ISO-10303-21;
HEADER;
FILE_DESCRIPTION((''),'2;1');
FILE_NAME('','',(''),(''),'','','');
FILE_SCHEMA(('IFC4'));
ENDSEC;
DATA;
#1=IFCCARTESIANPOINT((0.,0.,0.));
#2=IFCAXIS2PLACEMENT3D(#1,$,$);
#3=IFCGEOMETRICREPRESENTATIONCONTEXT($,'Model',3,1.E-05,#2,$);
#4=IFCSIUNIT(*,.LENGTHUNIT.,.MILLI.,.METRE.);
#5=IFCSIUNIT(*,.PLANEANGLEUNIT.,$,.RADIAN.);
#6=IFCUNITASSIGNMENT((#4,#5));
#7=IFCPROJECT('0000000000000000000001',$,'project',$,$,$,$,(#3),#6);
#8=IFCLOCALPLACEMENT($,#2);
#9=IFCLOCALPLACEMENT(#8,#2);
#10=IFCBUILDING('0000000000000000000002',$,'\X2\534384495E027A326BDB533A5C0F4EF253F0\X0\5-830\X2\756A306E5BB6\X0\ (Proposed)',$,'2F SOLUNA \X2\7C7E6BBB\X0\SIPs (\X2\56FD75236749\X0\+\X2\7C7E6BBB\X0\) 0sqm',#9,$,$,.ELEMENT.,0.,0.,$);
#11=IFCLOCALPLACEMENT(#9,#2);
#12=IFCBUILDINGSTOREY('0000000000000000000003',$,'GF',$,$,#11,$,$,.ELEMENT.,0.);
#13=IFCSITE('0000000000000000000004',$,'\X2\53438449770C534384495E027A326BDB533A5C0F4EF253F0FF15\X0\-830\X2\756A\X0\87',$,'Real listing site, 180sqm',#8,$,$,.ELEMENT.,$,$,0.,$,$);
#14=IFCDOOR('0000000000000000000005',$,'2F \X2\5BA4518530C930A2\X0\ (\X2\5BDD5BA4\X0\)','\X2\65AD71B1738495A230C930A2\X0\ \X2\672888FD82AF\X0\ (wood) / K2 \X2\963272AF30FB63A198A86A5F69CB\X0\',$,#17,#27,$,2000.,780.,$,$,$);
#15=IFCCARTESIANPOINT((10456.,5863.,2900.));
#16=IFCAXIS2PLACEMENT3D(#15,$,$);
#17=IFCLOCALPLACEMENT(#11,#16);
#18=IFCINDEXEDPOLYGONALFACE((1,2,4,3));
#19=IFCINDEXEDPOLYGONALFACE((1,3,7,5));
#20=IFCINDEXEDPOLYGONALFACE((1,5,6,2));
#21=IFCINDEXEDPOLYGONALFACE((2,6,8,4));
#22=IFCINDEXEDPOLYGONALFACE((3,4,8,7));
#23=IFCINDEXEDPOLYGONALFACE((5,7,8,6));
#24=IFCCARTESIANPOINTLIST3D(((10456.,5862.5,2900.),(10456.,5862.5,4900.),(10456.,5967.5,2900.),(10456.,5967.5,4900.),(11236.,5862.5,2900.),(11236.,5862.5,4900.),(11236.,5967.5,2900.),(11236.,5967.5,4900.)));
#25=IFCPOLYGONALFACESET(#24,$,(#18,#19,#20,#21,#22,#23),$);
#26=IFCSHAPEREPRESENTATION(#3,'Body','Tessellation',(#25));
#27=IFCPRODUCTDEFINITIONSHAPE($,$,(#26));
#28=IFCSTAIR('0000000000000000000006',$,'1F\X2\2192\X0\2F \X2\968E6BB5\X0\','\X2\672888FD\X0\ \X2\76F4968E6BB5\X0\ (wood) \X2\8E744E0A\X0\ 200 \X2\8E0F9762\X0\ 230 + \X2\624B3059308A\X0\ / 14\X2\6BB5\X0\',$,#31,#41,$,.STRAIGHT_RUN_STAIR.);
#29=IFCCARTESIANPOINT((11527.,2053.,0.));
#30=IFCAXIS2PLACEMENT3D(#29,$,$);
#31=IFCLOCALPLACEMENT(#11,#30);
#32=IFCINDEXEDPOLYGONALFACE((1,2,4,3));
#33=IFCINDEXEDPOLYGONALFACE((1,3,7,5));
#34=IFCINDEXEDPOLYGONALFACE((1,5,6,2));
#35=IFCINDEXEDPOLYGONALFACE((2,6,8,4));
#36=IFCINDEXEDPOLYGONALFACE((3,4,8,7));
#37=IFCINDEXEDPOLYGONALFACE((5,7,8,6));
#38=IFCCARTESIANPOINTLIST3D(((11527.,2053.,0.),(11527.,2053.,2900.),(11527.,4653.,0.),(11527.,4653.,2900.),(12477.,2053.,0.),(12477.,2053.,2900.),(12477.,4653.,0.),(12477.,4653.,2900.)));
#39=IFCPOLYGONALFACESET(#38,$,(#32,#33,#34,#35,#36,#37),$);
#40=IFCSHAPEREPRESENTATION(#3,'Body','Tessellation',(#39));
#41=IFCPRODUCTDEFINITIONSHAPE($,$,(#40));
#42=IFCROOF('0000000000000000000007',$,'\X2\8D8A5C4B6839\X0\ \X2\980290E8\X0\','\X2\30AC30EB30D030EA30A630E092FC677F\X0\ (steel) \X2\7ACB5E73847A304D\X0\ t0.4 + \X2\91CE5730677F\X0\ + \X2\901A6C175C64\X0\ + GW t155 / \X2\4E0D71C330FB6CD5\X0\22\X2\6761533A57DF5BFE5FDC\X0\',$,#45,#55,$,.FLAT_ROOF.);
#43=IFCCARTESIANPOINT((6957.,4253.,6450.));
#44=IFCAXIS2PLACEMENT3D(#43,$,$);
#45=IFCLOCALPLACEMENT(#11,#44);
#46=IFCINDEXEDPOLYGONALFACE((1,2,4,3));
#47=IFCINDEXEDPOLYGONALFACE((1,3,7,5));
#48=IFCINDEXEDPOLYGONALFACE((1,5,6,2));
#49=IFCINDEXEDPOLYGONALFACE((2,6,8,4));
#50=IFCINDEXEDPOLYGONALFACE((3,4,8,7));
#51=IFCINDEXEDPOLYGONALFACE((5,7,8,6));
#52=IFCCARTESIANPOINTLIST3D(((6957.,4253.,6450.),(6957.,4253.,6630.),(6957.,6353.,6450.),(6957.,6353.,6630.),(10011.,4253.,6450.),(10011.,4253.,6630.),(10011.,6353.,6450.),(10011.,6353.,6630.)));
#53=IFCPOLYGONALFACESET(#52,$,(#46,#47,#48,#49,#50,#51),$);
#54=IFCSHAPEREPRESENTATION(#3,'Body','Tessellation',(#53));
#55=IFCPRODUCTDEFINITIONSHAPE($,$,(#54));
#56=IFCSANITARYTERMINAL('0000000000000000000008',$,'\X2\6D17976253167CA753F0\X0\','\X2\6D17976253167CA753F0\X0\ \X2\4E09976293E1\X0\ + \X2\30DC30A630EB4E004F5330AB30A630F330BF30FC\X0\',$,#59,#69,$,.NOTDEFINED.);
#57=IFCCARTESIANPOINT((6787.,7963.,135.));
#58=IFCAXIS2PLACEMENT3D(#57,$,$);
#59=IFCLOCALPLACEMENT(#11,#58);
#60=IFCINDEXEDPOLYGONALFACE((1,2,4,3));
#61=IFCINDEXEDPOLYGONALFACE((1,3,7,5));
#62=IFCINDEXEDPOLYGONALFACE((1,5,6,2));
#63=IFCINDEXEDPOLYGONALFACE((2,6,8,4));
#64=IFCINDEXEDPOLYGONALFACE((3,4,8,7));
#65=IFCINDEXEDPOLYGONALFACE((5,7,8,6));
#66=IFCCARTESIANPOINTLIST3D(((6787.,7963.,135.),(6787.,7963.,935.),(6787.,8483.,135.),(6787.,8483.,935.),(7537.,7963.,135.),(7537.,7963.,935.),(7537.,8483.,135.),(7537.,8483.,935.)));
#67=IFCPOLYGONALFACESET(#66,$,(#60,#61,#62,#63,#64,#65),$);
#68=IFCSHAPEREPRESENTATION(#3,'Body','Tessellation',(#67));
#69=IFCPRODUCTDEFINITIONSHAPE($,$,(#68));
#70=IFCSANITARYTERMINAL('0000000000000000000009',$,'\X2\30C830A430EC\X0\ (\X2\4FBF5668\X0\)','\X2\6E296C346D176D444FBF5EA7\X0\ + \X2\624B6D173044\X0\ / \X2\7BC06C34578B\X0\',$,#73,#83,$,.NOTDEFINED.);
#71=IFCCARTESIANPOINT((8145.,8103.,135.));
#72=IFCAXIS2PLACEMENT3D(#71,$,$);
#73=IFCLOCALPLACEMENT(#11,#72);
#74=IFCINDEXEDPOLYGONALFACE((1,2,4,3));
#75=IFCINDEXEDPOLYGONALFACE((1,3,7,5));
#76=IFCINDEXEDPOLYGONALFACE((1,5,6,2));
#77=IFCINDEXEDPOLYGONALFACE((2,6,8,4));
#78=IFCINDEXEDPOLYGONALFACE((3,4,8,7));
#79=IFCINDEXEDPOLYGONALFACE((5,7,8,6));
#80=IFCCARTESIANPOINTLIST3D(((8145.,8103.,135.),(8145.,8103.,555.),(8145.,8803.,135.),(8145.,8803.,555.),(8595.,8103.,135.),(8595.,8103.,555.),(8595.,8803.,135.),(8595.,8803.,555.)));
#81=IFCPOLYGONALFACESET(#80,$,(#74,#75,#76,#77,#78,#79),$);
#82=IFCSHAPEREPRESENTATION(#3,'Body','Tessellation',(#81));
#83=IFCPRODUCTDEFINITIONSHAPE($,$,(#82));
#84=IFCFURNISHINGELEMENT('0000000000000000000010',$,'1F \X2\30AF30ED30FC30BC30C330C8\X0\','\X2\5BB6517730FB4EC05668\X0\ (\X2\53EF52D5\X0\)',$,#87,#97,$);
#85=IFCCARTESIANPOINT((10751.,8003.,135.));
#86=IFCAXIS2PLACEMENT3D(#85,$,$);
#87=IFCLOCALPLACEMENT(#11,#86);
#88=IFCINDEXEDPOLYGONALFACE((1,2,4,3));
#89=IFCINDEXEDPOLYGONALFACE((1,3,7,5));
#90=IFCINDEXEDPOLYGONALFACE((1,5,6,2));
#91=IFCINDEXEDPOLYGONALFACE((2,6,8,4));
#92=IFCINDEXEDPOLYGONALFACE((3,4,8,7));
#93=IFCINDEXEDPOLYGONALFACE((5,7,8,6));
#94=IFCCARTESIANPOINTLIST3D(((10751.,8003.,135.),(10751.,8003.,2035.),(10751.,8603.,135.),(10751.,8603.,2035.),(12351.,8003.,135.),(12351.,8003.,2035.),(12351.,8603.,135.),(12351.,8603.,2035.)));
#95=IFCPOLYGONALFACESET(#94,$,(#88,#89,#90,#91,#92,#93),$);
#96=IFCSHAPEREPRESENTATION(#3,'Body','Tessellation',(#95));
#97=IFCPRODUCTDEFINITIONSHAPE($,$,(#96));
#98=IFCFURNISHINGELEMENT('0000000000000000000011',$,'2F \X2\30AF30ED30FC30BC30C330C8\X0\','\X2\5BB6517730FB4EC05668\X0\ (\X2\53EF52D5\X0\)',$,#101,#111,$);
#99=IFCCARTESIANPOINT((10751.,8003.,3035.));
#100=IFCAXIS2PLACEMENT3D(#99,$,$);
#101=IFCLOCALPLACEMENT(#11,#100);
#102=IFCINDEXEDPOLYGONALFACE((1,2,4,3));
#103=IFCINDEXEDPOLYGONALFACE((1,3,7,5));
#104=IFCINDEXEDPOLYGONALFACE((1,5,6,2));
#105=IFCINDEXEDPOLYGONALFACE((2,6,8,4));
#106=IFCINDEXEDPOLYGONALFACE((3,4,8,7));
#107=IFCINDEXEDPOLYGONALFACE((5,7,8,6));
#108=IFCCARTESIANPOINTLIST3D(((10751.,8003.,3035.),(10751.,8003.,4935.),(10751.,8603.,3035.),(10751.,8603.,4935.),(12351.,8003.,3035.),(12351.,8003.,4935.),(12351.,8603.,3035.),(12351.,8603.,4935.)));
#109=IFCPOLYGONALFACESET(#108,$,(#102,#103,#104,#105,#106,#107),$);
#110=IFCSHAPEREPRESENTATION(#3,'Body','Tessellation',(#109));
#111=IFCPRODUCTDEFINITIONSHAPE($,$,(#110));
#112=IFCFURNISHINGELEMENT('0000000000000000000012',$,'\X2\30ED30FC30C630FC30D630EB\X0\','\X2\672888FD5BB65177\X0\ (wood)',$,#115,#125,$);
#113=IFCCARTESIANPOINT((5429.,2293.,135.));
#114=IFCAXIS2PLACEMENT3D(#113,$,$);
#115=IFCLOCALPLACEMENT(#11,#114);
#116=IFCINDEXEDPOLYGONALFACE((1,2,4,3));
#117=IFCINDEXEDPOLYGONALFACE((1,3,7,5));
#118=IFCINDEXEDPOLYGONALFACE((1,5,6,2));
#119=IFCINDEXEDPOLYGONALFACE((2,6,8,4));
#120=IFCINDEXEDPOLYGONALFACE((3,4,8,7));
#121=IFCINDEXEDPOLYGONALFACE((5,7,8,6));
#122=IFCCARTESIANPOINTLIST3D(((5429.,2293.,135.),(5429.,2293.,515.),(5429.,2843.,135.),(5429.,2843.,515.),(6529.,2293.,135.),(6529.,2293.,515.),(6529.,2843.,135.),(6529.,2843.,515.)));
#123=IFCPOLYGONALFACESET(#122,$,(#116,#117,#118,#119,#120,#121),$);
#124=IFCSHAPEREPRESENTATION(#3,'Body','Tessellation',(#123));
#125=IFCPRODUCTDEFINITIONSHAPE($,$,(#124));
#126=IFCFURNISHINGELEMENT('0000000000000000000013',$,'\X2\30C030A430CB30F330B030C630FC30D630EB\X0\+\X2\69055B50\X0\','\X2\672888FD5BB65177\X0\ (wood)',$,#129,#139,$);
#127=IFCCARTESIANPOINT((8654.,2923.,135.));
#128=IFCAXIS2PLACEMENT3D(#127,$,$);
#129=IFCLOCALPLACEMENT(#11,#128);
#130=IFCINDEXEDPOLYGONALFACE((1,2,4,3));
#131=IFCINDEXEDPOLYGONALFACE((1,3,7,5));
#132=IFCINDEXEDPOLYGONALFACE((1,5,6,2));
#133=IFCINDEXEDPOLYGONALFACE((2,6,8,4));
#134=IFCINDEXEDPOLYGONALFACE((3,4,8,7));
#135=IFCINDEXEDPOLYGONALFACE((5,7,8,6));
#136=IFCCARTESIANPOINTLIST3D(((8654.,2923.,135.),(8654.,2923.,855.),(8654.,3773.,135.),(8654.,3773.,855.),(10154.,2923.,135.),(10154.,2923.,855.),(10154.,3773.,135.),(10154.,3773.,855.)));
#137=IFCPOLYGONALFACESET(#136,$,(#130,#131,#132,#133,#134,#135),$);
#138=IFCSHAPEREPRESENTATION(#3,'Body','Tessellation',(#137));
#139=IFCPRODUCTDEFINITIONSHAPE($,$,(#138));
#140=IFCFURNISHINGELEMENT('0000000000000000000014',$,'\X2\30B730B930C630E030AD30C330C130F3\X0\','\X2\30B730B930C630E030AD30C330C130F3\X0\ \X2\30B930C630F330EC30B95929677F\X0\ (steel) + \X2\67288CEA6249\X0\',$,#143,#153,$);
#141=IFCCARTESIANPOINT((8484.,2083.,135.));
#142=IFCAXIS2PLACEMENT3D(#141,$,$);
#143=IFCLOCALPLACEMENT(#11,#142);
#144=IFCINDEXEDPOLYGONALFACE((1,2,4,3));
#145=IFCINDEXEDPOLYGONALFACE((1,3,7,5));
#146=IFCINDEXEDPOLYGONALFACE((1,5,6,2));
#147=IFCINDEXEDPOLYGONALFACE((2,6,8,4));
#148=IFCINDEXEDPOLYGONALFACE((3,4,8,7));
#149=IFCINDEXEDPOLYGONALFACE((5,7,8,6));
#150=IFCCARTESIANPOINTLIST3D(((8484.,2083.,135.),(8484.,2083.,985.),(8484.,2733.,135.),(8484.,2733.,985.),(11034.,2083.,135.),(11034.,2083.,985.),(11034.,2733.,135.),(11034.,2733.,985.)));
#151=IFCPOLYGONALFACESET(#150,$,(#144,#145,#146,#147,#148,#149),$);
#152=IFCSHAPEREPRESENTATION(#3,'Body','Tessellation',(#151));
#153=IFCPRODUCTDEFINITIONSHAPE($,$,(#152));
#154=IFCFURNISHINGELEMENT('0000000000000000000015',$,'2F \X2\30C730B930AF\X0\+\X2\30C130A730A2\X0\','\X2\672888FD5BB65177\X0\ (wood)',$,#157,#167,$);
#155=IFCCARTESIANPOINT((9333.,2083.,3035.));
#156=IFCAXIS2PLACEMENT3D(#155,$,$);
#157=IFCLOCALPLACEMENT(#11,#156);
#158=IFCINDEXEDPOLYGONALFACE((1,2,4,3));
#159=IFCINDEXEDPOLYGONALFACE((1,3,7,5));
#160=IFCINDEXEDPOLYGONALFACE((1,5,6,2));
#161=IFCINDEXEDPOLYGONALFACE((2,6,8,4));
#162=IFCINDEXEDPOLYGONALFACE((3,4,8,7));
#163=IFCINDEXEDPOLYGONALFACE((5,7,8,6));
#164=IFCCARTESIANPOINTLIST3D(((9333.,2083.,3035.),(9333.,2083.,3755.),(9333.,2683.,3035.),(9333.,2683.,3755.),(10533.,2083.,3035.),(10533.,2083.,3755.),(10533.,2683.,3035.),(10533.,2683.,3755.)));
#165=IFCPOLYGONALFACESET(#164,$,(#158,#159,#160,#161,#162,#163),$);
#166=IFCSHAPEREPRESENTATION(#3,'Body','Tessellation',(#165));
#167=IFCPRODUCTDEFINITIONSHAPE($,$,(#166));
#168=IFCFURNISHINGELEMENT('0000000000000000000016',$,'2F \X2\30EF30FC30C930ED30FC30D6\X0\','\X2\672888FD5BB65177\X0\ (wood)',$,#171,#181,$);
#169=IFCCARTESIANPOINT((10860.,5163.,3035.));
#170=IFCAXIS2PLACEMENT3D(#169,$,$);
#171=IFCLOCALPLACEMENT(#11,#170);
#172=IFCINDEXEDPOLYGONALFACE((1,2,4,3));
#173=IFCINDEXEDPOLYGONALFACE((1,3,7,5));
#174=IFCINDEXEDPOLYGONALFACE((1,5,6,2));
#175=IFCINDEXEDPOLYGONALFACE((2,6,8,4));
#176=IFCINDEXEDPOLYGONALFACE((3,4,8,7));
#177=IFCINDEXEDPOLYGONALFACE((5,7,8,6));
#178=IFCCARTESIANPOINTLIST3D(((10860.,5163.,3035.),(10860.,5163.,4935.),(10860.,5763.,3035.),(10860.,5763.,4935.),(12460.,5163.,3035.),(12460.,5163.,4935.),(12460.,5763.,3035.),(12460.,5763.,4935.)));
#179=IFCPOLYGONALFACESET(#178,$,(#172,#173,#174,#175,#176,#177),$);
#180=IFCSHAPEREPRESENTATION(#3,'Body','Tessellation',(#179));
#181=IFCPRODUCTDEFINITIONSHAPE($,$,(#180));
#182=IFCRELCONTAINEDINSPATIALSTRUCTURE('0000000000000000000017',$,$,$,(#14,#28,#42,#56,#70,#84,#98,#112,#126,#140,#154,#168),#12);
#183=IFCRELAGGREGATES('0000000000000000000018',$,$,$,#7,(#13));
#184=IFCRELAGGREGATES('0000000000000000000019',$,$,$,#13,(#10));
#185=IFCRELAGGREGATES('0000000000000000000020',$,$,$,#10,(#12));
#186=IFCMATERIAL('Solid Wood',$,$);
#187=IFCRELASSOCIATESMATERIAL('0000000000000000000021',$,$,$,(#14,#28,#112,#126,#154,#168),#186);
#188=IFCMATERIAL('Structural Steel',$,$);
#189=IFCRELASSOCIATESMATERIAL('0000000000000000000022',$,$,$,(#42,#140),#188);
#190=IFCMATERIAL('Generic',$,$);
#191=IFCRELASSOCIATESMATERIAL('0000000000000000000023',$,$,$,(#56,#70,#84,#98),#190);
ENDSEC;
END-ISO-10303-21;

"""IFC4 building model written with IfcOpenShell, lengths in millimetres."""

from ifc_helpers import new_model, si_unit, frame, frame_2d, origin, place, context, project, spatial, rectangle, extrude, material, element, save


model = new_model("IFC4")

# Units and contexts
model_context = context("Model", 3, precision=1e-05, world=origin())
ifc_project = project(units=[si_unit("LENGTHUNIT", "METRE", prefix="MILLI"), si_unit("PLANEANGLEUNIT", "RADIAN")], contexts=[model_context])

# Site, building, storey
site_placement = place(None, origin())
site = spatial("IfcSite", under=ifc_project, at=site_placement, Name="千葉県千葉市稲毛区小仲台５-830番87", ObjectType="Real listing site, 180sqm", CompositionType="ELEMENT", RefElevation=0.0)
building_placement = place(site_placement, origin())
building = spatial("IfcBuilding", under=site, at=building_placement, Name="千葉市稲毛区小仲台5-830番の家 (Proposed)", ObjectType="2F SOLUNA 籾殻SIPs (国産杉+籾殻) 0sqm", CompositionType="ELEMENT", ElevationOfRefHeight=0.0, ElevationOfTerrain=0.0)
storey_placement = place(building_placement, origin())
storey = spatial("IfcBuildingStorey", under=building, at=storey_placement, Name="GF", CompositionType="ELEMENT", Elevation=0.0)

# Shared definitions
ifc_material_1 = material(Name="Solid Wood")

# Door
door_1_placement = place(storey_placement, frame((10456.0, 5863.0, 2900.0)))
element("IfcDoor", 1, at=door_1_placement, inside=storey, material=ifc_material_1, Name="2F 室内ドア (寝室)", Description="断熱玄関ドア 木製芯 (wood) / K2 防犯・採風機構", OverallHeight=2000.0, OverallWidth=780.0, context=model_context, shape_type="SweptSolid", body=[
    extrude(rectangle(XDim=780.0, YDim=105.0, at=frame_2d((390.0, 52.0))), frame((10456.0, 5863.0, 2900.0)), (0.0, 0.0, 1.0), 2000.0),
])

# Stair
stair_placement = place(storey_placement, frame((11527.0, 2053.0, 0.0)))
element("IfcStair", 2, at=stair_placement, inside=storey, material=ifc_material_1, Name="1F→2F 階段", Description="木製 直階段 (wood) 蹴上 200 踏面 230 + 手すり / 14段", PredefinedType="STRAIGHT_RUN_STAIR", context=model_context, shape_type="SweptSolid", body=[
    extrude(rectangle(XDim=950.0, YDim=2600.0, at=frame_2d((475.0, 1300.0))), frame((11527.0, 2053.0, 0.0)), (0.0, 0.0, 1.0), 2900.0),
])

# Roof
ifc_material_2 = material(Name="Structural Steel")
roof_placement = place(storey_placement, frame((6957.0, 4253.0, 6450.0)))
element("IfcRoof", 3, at=roof_placement, inside=storey, material=ifc_material_2, Name="越屋根 頂部", Description="ガルバリウム鋼板 (steel) 立平葺き t0.4 + 野地板 + 通気層 + GW t155 / 不燃・法22条区域対応", PredefinedType="FLAT_ROOF", context=model_context, shape_type="SweptSolid", body=[
    extrude(rectangle(XDim=3054.0, YDim=2100.0, at=frame_2d((1527.0, 1050.0))), frame((6957.0, 4253.0, 6450.0)), (0.0, 0.0, 1.0), 180.0),
])

# Sanitary terminals
ifc_material_3 = material(Name="Generic")
sanitary_terminal_1_placement = place(storey_placement, frame((6787.0, 7963.0, 135.0)))
element("IfcSanitaryTerminal", 4, at=sanitary_terminal_1_placement, inside=storey, material=ifc_material_3, Name="洗面化粧台", Description="洗面化粧台 三面鏡 + ボウル一体カウンター", PredefinedType="NOTDEFINED", context=model_context, shape_type="SweptSolid", body=[
    extrude(rectangle(XDim=750.0, YDim=520.0, at=frame_2d((375.0, 260.0))), frame((6787.0, 7963.0, 135.0)), (0.0, 0.0, 1.0), 800.0),
])
sanitary_terminal_2_placement = place(storey_placement, frame((8145.0, 8103.0, 135.0)))
element("IfcSanitaryTerminal", 5, at=sanitary_terminal_2_placement, inside=storey, material=ifc_material_3, Name="トイレ (便器)", Description="温水洗浄便座 + 手洗い / 節水型", PredefinedType="NOTDEFINED", context=model_context, shape_type="SweptSolid", body=[
    extrude(rectangle(XDim=450.0, YDim=700.0, at=frame_2d((225.0, 350.0))), frame((8145.0, 8103.0, 135.0)), (0.0, 0.0, 1.0), 420.0),
])

# Furnishing elements
furnishing_1_placement = place(storey_placement, frame((10751.0, 8003.0, 135.0)))
element("IfcFurnishingElement", 6, at=furnishing_1_placement, inside=storey, material=ifc_material_3, Name="1F クローゼット", Description="家具・什器 (可動)", context=model_context, shape_type="SweptSolid", body=[
    extrude(rectangle(XDim=1600.0, YDim=600.0, at=frame_2d((800.0, 300.0))), frame((10751.0, 8003.0, 135.0)), (0.0, 0.0, 1.0), 1900.0),
])
furnishing_2_placement = place(storey_placement, frame((10751.0, 8003.0, 3035.0)))
element("IfcFurnishingElement", 7, at=furnishing_2_placement, inside=storey, material=ifc_material_3, Name="2F クローゼット", Description="家具・什器 (可動)", context=model_context, shape_type="SweptSolid", body=[
    extrude(rectangle(XDim=1600.0, YDim=600.0, at=frame_2d((800.0, 300.0))), frame((10751.0, 8003.0, 3035.0)), (0.0, 0.0, 1.0), 1900.0),
])
furnishing_3_placement = place(storey_placement, frame((5429.0, 2293.0, 135.0)))
element("IfcFurnishingElement", 8, at=furnishing_3_placement, inside=storey, material=ifc_material_1, Name="ローテーブル", Description="木製家具 (wood)", context=model_context, shape_type="SweptSolid", body=[
    extrude(rectangle(XDim=1100.0, YDim=550.0, at=frame_2d((550.0, 275.0))), frame((5429.0, 2293.0, 135.0)), (0.0, 0.0, 1.0), 380.0),
])
furnishing_4_placement = place(storey_placement, frame((8654.0, 2923.0, 135.0)))
element("IfcFurnishingElement", 9, at=furnishing_4_placement, inside=storey, material=ifc_material_1, Name="ダイニングテーブル+椅子", Description="木製家具 (wood)", context=model_context, shape_type="SweptSolid", body=[
    extrude(rectangle(XDim=1500.0, YDim=850.0, at=frame_2d((750.0, 425.0))), frame((8654.0, 2923.0, 135.0)), (0.0, 0.0, 1.0), 720.0),
])
furnishing_5_placement = place(storey_placement, frame((8484.0, 2083.0, 135.0)))
element("IfcFurnishingElement", 10, at=furnishing_5_placement, inside=storey, material=ifc_material_2, Name="システムキッチン", Description="システムキッチン ステンレス天板 (steel) + 木質扉", context=model_context, shape_type="SweptSolid", body=[
    extrude(rectangle(XDim=2550.0, YDim=650.0, at=frame_2d((1275.0, 325.0))), frame((8484.0, 2083.0, 135.0)), (0.0, 0.0, 1.0), 850.0),
])
furnishing_6_placement = place(storey_placement, frame((9333.0, 2083.0, 3035.0)))
element("IfcFurnishingElement", 11, at=furnishing_6_placement, inside=storey, material=ifc_material_1, Name="2F デスク+チェア", Description="木製家具 (wood)", context=model_context, shape_type="SweptSolid", body=[
    extrude(rectangle(XDim=1200.0, YDim=600.0, at=frame_2d((600.0, 300.0))), frame((9333.0, 2083.0, 3035.0)), (0.0, 0.0, 1.0), 720.0),
])
furnishing_7_placement = place(storey_placement, frame((10860.0, 5163.0, 3035.0)))
element("IfcFurnishingElement", 12, at=furnishing_7_placement, inside=storey, material=ifc_material_1, Name="2F ワードローブ", Description="木製家具 (wood)", context=model_context, shape_type="SweptSolid", body=[
    extrude(rectangle(XDim=1600.0, YDim=600.0, at=frame_2d((800.0, 300.0))), frame((10860.0, 5163.0, 3035.0)), (0.0, 0.0, 1.0), 1900.0),
])

save(model, "model.ifc")
